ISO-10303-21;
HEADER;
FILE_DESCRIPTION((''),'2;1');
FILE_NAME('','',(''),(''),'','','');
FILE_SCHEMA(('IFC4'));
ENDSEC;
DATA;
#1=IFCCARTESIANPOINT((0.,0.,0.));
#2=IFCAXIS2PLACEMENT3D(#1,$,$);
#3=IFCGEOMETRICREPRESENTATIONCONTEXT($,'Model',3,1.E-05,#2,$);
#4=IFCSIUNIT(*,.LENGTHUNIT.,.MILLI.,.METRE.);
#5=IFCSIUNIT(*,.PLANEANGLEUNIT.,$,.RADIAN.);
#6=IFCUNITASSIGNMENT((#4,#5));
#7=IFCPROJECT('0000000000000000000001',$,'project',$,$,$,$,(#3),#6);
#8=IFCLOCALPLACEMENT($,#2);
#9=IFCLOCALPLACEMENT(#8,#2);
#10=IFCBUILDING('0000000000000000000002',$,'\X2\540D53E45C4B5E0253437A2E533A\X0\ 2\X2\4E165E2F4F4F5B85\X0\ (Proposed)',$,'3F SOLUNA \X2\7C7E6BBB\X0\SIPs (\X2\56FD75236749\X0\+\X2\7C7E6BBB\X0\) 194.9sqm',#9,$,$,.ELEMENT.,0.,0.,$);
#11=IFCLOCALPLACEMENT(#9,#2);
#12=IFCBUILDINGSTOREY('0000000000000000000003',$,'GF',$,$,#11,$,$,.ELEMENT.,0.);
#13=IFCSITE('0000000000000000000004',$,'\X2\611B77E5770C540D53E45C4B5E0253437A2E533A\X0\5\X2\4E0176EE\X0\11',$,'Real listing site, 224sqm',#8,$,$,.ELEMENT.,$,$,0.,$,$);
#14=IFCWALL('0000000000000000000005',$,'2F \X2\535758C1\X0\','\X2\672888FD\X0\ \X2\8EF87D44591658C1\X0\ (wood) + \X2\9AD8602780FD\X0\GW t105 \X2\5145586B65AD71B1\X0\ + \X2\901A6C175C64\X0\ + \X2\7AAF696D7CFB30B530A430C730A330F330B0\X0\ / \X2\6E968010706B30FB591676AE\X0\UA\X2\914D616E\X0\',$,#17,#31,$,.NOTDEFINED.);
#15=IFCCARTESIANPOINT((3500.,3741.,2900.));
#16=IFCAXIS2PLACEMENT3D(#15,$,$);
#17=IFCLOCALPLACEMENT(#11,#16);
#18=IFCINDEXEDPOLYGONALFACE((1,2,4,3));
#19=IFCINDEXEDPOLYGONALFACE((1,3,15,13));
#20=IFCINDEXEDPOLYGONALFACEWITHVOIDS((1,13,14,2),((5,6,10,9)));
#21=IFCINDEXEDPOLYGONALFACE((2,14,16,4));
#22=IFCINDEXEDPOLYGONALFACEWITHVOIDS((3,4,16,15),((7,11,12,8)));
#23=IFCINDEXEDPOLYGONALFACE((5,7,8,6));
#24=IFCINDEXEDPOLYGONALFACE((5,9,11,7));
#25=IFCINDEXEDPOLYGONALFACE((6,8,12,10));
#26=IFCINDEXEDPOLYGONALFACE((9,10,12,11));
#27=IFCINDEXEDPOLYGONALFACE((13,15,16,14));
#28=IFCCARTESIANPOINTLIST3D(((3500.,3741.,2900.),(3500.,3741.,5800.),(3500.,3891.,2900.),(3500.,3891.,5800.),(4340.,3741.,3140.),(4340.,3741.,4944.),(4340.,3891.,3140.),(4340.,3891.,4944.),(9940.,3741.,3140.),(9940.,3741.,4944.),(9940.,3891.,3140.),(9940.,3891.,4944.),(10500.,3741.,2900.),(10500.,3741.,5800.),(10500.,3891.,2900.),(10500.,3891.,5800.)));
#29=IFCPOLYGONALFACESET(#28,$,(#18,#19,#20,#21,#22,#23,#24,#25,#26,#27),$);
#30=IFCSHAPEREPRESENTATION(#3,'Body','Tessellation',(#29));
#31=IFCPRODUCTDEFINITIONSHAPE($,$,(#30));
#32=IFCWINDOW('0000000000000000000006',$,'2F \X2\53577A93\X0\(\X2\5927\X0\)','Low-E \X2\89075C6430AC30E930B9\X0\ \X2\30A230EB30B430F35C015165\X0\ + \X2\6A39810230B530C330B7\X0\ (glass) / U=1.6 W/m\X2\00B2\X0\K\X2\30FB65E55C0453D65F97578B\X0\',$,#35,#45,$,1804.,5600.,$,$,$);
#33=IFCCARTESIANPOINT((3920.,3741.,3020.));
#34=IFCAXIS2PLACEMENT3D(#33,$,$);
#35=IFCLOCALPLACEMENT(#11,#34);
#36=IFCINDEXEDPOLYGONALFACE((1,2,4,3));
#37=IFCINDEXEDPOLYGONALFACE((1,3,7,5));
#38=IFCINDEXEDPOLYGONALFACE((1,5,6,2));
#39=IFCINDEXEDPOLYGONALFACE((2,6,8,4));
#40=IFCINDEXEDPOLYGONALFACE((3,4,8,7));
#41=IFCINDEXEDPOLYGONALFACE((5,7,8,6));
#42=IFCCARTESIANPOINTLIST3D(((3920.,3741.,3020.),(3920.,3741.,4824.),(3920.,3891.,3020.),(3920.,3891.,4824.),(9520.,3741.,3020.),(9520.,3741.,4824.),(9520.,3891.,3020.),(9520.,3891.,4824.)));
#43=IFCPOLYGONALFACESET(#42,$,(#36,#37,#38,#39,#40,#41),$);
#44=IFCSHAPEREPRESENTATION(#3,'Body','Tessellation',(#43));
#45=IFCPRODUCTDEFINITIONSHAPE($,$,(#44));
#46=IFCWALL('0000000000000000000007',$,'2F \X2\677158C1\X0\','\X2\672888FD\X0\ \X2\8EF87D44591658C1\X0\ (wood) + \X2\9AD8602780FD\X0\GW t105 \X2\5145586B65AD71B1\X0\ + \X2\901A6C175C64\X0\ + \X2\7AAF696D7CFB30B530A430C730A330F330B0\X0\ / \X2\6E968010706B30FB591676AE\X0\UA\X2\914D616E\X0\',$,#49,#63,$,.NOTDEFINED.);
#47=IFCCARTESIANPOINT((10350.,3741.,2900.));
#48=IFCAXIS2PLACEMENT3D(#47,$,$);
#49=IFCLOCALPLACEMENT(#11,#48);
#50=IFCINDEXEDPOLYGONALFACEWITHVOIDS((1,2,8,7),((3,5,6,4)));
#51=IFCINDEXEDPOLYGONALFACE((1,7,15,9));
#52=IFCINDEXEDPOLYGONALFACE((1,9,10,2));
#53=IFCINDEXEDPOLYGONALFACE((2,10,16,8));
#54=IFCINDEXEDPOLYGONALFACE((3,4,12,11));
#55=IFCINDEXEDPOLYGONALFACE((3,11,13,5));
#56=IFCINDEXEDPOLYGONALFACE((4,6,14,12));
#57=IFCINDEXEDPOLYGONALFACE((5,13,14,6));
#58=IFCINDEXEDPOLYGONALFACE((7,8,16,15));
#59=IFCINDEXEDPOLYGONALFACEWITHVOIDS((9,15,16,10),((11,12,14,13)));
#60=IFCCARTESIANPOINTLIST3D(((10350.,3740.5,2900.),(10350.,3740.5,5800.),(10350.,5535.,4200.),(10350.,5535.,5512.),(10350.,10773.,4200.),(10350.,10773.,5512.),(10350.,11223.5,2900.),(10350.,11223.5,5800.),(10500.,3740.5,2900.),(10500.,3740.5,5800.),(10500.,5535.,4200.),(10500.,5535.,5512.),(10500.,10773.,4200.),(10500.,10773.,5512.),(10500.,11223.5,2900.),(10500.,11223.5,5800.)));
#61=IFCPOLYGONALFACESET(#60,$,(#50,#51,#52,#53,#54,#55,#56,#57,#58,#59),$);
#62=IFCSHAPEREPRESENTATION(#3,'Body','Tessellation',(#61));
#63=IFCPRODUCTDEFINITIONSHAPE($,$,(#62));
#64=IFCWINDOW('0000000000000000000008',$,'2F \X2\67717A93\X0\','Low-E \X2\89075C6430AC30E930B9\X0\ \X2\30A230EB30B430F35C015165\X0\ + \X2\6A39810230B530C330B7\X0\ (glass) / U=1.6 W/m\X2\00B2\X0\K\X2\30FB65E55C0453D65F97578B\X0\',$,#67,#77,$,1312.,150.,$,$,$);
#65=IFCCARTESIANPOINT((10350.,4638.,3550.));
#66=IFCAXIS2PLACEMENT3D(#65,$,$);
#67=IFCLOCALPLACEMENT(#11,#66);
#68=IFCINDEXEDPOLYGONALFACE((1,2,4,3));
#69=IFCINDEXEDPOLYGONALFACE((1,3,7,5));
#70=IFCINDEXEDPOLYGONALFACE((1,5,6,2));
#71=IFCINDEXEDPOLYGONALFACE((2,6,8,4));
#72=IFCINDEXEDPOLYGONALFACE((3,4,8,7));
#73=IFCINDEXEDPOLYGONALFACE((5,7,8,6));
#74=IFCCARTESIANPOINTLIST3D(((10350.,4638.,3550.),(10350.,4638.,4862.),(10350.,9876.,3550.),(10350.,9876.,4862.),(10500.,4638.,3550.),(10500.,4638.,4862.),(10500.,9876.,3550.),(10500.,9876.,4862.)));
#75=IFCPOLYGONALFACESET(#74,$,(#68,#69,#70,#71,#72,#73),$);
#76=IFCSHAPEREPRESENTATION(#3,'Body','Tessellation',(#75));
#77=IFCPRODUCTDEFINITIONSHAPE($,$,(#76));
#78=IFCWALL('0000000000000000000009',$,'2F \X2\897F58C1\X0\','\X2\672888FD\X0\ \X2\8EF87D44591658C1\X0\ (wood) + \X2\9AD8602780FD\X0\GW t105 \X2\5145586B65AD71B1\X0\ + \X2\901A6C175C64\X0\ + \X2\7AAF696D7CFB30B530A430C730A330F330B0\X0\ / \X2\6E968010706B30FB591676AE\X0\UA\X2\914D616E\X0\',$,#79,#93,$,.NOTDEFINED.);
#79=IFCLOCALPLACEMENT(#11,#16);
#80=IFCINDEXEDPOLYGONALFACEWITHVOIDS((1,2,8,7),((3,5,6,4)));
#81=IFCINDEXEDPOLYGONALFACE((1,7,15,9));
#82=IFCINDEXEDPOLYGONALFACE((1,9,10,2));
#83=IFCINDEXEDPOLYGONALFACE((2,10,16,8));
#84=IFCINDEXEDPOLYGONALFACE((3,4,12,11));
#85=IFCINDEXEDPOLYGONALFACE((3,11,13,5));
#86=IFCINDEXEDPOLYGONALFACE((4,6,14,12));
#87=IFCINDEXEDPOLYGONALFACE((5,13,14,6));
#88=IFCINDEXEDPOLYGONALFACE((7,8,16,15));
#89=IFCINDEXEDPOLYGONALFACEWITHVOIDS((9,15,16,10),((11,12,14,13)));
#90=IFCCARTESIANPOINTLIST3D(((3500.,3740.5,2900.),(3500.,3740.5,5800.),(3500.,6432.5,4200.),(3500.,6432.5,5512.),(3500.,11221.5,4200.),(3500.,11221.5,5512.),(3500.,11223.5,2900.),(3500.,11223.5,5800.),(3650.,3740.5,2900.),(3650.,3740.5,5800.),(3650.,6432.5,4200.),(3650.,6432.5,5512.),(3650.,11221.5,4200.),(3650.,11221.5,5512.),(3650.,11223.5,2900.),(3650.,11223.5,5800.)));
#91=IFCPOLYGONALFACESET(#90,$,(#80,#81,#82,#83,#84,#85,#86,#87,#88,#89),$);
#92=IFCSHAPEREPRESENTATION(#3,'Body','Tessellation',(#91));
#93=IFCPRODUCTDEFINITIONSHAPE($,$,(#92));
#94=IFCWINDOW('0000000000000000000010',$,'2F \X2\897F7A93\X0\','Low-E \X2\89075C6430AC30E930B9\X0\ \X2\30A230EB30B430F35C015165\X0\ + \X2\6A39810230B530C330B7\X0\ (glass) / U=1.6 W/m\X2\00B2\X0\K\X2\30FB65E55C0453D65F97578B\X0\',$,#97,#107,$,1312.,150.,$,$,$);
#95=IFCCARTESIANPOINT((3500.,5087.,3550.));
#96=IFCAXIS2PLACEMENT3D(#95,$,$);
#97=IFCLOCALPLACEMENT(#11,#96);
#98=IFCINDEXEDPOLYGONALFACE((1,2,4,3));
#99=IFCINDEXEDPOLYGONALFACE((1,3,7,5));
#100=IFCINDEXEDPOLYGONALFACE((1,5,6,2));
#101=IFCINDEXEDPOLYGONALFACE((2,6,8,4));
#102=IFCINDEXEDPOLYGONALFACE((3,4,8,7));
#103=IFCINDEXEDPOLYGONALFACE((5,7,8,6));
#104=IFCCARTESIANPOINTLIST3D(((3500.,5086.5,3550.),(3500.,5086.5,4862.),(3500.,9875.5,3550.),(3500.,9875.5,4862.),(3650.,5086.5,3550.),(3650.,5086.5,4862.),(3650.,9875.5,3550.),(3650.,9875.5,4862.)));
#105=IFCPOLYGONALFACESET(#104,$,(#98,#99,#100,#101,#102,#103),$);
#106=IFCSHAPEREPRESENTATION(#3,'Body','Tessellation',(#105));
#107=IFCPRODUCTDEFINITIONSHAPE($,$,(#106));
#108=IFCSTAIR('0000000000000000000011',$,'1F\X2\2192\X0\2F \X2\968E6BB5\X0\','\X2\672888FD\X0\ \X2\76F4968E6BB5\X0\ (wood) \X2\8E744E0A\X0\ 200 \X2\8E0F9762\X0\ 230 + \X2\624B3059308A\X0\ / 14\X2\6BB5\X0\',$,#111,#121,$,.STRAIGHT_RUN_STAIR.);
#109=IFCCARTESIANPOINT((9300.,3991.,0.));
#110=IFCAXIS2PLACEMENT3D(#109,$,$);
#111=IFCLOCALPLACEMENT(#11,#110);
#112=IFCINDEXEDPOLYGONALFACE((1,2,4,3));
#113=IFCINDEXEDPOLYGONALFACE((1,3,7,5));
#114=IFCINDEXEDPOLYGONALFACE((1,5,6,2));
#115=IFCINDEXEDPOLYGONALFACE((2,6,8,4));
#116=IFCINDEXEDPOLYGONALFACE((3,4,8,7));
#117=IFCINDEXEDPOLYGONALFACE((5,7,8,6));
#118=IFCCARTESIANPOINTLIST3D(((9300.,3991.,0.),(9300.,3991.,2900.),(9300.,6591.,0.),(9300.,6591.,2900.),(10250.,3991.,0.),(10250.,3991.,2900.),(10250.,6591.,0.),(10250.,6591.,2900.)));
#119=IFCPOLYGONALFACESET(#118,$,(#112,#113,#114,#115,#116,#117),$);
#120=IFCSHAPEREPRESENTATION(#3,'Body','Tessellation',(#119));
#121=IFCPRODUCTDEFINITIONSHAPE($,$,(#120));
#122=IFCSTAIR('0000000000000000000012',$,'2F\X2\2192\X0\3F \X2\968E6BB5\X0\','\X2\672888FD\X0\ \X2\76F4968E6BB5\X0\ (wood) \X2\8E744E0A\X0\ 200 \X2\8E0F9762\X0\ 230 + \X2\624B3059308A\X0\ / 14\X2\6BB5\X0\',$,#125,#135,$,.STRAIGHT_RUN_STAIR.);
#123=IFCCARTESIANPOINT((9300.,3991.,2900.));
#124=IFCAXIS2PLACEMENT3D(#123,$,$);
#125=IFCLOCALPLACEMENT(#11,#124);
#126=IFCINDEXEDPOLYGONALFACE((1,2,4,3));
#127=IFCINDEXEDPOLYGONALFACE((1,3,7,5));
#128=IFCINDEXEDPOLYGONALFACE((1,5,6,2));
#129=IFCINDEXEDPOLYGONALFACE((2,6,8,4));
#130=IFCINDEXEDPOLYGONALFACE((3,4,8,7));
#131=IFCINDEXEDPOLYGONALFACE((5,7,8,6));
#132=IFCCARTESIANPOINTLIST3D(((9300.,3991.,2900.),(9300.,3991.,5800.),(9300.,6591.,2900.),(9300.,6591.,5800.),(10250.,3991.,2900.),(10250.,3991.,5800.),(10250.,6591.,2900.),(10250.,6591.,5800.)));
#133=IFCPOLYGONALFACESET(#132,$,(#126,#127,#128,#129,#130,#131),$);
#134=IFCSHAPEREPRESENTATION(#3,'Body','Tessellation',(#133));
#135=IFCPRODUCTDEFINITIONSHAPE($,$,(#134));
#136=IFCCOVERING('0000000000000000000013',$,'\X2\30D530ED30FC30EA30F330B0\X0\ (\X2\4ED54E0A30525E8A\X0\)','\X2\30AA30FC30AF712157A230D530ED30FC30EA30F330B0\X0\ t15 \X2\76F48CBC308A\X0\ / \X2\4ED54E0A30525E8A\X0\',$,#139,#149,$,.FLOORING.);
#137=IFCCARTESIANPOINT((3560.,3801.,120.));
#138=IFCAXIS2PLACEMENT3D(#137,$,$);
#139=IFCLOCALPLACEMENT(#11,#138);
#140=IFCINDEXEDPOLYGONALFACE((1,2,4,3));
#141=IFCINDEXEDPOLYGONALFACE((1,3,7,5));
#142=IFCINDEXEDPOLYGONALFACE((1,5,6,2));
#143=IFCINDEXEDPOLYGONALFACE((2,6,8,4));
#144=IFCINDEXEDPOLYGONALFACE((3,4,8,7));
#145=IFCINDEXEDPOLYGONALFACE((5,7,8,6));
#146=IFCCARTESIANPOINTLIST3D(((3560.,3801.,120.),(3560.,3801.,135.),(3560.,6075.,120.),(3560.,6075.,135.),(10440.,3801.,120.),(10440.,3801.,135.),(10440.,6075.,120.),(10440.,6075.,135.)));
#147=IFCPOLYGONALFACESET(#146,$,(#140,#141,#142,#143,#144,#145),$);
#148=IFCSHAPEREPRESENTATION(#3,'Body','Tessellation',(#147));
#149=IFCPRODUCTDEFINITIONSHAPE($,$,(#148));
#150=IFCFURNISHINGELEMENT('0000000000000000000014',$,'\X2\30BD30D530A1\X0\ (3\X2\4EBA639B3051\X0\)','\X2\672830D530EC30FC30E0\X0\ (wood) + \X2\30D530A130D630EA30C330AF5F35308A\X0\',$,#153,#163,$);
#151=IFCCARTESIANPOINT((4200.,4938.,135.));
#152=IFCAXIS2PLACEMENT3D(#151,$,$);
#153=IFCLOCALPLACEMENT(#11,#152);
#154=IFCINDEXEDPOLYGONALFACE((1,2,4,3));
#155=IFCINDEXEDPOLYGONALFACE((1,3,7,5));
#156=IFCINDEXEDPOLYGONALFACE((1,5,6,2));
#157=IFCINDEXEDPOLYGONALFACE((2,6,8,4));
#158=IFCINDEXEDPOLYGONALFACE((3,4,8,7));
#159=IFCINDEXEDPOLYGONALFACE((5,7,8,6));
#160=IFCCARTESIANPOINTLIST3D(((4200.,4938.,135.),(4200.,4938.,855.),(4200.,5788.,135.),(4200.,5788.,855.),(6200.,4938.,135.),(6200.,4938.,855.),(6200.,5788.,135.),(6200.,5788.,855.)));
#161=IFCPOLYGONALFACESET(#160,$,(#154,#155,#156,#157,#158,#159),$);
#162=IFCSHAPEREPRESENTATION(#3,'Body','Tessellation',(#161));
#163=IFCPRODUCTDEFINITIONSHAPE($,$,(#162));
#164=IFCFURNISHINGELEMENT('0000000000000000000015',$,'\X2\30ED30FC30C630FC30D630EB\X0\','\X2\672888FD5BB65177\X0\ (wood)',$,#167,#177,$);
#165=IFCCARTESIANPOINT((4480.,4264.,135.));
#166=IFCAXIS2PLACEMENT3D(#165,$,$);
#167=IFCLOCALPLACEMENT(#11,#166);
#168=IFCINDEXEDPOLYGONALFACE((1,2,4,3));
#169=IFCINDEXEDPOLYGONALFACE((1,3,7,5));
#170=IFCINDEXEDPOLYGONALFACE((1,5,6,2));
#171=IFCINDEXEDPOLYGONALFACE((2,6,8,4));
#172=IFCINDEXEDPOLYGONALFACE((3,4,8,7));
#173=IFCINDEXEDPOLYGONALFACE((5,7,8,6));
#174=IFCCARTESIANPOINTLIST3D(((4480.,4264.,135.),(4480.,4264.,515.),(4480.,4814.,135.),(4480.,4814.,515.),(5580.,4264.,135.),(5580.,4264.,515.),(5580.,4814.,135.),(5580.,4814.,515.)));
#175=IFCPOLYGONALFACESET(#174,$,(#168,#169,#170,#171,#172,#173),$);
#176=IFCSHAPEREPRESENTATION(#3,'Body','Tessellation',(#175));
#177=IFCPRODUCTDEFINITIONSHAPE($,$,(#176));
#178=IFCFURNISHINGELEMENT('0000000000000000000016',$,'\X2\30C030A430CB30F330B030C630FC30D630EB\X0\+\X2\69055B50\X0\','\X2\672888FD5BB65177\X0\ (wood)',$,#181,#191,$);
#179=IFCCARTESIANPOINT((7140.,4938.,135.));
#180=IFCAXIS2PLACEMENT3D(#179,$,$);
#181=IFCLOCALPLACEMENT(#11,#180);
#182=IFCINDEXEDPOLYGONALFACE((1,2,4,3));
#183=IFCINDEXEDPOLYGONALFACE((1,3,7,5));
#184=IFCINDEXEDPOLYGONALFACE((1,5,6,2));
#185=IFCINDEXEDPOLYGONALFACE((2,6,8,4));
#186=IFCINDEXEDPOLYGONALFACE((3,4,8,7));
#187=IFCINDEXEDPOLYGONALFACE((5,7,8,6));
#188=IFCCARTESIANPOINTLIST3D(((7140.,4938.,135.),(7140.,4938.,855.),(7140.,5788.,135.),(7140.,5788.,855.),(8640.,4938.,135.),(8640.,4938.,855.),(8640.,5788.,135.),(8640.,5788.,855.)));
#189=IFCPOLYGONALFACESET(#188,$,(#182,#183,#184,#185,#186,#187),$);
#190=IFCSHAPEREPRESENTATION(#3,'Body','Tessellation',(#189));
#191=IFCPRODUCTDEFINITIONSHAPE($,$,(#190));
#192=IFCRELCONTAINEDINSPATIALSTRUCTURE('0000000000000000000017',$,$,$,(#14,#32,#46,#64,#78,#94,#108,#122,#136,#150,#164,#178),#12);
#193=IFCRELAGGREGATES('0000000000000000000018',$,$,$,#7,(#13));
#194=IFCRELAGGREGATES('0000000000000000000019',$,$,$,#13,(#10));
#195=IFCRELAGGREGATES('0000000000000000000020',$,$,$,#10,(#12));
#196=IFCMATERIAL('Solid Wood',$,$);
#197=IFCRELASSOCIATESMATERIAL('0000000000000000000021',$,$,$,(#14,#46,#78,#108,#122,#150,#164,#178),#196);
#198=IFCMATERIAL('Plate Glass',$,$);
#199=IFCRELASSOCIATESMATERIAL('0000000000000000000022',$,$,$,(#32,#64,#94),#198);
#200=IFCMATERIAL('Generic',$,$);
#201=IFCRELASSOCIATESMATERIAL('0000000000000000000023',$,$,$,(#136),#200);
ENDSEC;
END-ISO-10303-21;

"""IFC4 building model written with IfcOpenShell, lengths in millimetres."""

from ifc_helpers import new_model, si_unit, frame, frame_2d, origin, place, context, project, spatial, rectangle, extrude, material, element, fill, save


model = new_model("IFC4")

# Units and contexts
model_context = context("Model", 3, precision=1e-05, world=origin())
ifc_project = project(units=[si_unit("LENGTHUNIT", "METRE", prefix="MILLI"), si_unit("PLANEANGLEUNIT", "RADIAN")], contexts=[model_context])

# Site, building, storey
site_placement = place(None, origin())
site = spatial("IfcSite", under=ifc_project, at=site_placement, Name="愛知県名古屋市千種区5丁目11", ObjectType="Real listing site, 224sqm", CompositionType="ELEMENT", RefElevation=0.0)
building_placement = place(site_placement, origin())
building = spatial("IfcBuilding", under=site, at=building_placement, Name="名古屋市千種区 2世帯住宅 (Proposed)", ObjectType="3F SOLUNA 籾殻SIPs (国産杉+籾殻) 194.9sqm", CompositionType="ELEMENT", ElevationOfRefHeight=0.0, ElevationOfTerrain=0.0)
storey_placement = place(building_placement, origin())
storey = spatial("IfcBuildingStorey", under=building, at=storey_placement, Name="GF", CompositionType="ELEMENT", Elevation=0.0)

# Shared definitions
ifc_material_1 = material(Name="Solid Wood")

# Shared definitions
ifc_material_2 = material(Name="Plate Glass")

# Walls, openings, windows
wall_1_placement = place(storey_placement, frame((3500.0, 3741.0, 2900.0)))
wall_1 = element("IfcWall", 1, at=wall_1_placement, inside=storey, material=ifc_material_1, Name="2F 南壁", Description="木製 軸組外壁 (wood) + 高性能GW t105 充填断熱 + 通気層 + 窯業系サイディング / 準耐火・外皮UA配慮", PredefinedType="NOTDEFINED", context=model_context, shape_type="SweptSolid", body=[
    extrude(rectangle(XDim=7000.0, YDim=150.0, at=frame_2d((3500.0, 75.0))), frame((3500.0, 3741.0, 2900.0)), (0.0, 0.0, 1.0), 2900.0),
])
opening_1_placement = place(storey_placement, frame((3920.0, 3741.0, 3020.0)))
opening_1 = element("IfcOpeningElement", 2, at=opening_1_placement, cuts=wall_1, PredefinedType="NOTDEFINED", context=model_context, shape_type="SweptSolid", body=[
    extrude(rectangle(XDim=5600.0, YDim=150.0, at=frame_2d((2800.0, 75.0))), frame((3920.0, 3741.0, 3020.0)), (0.0, 0.0, 1.0), 1804.0),
])
window_1_placement = place(storey_placement, frame((3920.0, 3741.0, 3020.0)))
window_1 = element("IfcWindow", 3, at=window_1_placement, inside=storey, material=ifc_material_2, Name="2F 南窓(大)", Description="Low-E 複層ガラス アルゴン封入 + 樹脂サッシ (glass) / U=1.6 W/m²K・日射取得型", OverallHeight=1804.0, OverallWidth=5600.0, context=model_context, shape_type="SweptSolid", body=[
    extrude(rectangle(XDim=5600.0, YDim=150.0, at=frame_2d((2800.0, 75.0))), frame((3920.0, 3741.0, 3020.0)), (0.0, 0.0, 1.0), 1804.0),
])
fill(opening_1, window_1)
wall_2_placement = place(storey_placement, frame((10350.0, 3741.0, 2900.0)))
wall_2 = element("IfcWall", 4, at=wall_2_placement, inside=storey, material=ifc_material_1, Name="2F 東壁", Description="木製 軸組外壁 (wood) + 高性能GW t105 充填断熱 + 通気層 + 窯業系サイディング / 準耐火・外皮UA配慮", PredefinedType="NOTDEFINED", context=model_context, shape_type="SweptSolid", body=[
    extrude(rectangle(XDim=150.0, YDim=7483.0, at=frame_2d((75.0, 3741.0))), frame((10350.0, 3741.0, 2900.0)), (0.0, 0.0, 1.0), 2900.0),
])
opening_2_placement = place(storey_placement, frame((10350.0, 4638.0, 3550.0)))
opening_2 = element("IfcOpeningElement", 5, at=opening_2_placement, cuts=wall_2, PredefinedType="NOTDEFINED", context=model_context, shape_type="SweptSolid", body=[
    extrude(rectangle(XDim=150.0, YDim=5238.0, at=frame_2d((75.0, 2619.0))), frame((10350.0, 4638.0, 3550.0)), (0.0, 0.0, 1.0), 1312.0),
])
window_2_placement = place(storey_placement, frame((10350.0, 4638.0, 3550.0)))
window_2 = element("IfcWindow", 6, at=window_2_placement, inside=storey, material=ifc_material_2, Name="2F 東窓", Description="Low-E 複層ガラス アルゴン封入 + 樹脂サッシ (glass) / U=1.6 W/m²K・日射取得型", OverallHeight=1312.0, OverallWidth=150.0, context=model_context, shape_type="SweptSolid", body=[
    extrude(rectangle(XDim=150.0, YDim=5238.0, at=frame_2d((75.0, 2619.0))), frame((10350.0, 4638.0, 3550.0)), (0.0, 0.0, 1.0), 1312.0),
])
fill(opening_2, window_2)
wall_3_placement = place(storey_placement, frame((3500.0, 3741.0, 2900.0)))
wall_3 = element("IfcWall", 7, at=wall_3_placement, inside=storey, material=ifc_material_1, Name="2F 西壁", Description="木製 軸組外壁 (wood) + 高性能GW t105 充填断熱 + 通気層 + 窯業系サイディング / 準耐火・外皮UA配慮", PredefinedType="NOTDEFINED", context=model_context, shape_type="SweptSolid", body=[
    extrude(rectangle(XDim=150.0, YDim=7483.0, at=frame_2d((75.0, 3741.0))), frame((3500.0, 3741.0, 2900.0)), (0.0, 0.0, 1.0), 2900.0),
])
opening_3_placement = place(storey_placement, frame((3500.0, 5087.0, 3550.0)))
opening_3 = element("IfcOpeningElement", 8, at=opening_3_placement, cuts=wall_3, PredefinedType="NOTDEFINED", context=model_context, shape_type="SweptSolid", body=[
    extrude(rectangle(XDim=150.0, YDim=4789.0, at=frame_2d((75.0, 2394.0))), frame((3500.0, 5087.0, 3550.0)), (0.0, 0.0, 1.0), 1312.0),
])
window_3_placement = place(storey_placement, frame((3500.0, 5087.0, 3550.0)))
window_3 = element("IfcWindow", 9, at=window_3_placement, inside=storey, material=ifc_material_2, Name="2F 西窓", Description="Low-E 複層ガラス アルゴン封入 + 樹脂サッシ (glass) / U=1.6 W/m²K・日射取得型", OverallHeight=1312.0, OverallWidth=150.0, context=model_context, shape_type="SweptSolid", body=[
    extrude(rectangle(XDim=150.0, YDim=4789.0, at=frame_2d((75.0, 2394.0))), frame((3500.0, 5087.0, 3550.0)), (0.0, 0.0, 1.0), 1312.0),
])
fill(opening_3, window_3)

# Stairs
stair_1_placement = place(storey_placement, frame((9300.0, 3991.0, 0.0)))
element("IfcStair", 10, at=stair_1_placement, inside=storey, material=ifc_material_1, Name="1F→2F 階段", Description="木製 直階段 (wood) 蹴上 200 踏面 230 + 手すり / 14段", PredefinedType="STRAIGHT_RUN_STAIR", context=model_context, shape_type="SweptSolid", body=[
    extrude(rectangle(XDim=950.0, YDim=2600.0, at=frame_2d((475.0, 1300.0))), frame((9300.0, 3991.0, 0.0)), (0.0, 0.0, 1.0), 2900.0),
])
stair_2_placement = place(storey_placement, frame((9300.0, 3991.0, 2900.0)))
element("IfcStair", 11, at=stair_2_placement, inside=storey, material=ifc_material_1, Name="2F→3F 階段", Description="木製 直階段 (wood) 蹴上 200 踏面 230 + 手すり / 14段", PredefinedType="STRAIGHT_RUN_STAIR", context=model_context, shape_type="SweptSolid", body=[
    extrude(rectangle(XDim=950.0, YDim=2600.0, at=frame_2d((475.0, 1300.0))), frame((9300.0, 3991.0, 2900.0)), (0.0, 0.0, 1.0), 2900.0),
])

# Covering
ifc_material_3 = material(Name="Generic")
covering_placement = place(storey_placement, frame((3560.0, 3801.0, 120.0)))
element("IfcCovering", 12, at=covering_placement, inside=storey, material=ifc_material_3, Name="フローリング (仕上げ床)", Description="オーク無垢フローリング t15 直貼り / 仕上げ床", PredefinedType="FLOORING", context=model_context, shape_type="SweptSolid", body=[
    extrude(rectangle(XDim=6880.0, YDim=2274.0, at=frame_2d((3440.0, 1137.0))), frame((3560.0, 3801.0, 120.0)), (0.0, 0.0, 1.0), 15.0),
])

# Furnishing elements
furnishing_1_placement = place(storey_placement, frame((4200.0, 4938.0, 135.0)))
element("IfcFurnishingElement", 13, at=furnishing_1_placement, inside=storey, material=ifc_material_1, Name="ソファ (3人掛け)", Description="木フレーム (wood) + ファブリック張り", context=model_context, shape_type="SweptSolid", body=[
    extrude(rectangle(XDim=2000.0, YDim=850.0, at=frame_2d((1000.0, 425.0))), frame((4200.0, 4938.0, 135.0)), (0.0, 0.0, 1.0), 720.0),
])
furnishing_2_placement = place(storey_placement, frame((4480.0, 4264.0, 135.0)))
element("IfcFurnishingElement", 14, at=furnishing_2_placement, inside=storey, material=ifc_material_1, Name="ローテーブル", Description="木製家具 (wood)", context=model_context, shape_type="SweptSolid", body=[
    extrude(rectangle(XDim=1100.0, YDim=550.0, at=frame_2d((550.0, 275.0))), frame((4480.0, 4264.0, 135.0)), (0.0, 0.0, 1.0), 380.0),
])
furnishing_3_placement = place(storey_placement, frame((7140.0, 4938.0, 135.0)))
element("IfcFurnishingElement", 15, at=furnishing_3_placement, inside=storey, material=ifc_material_1, Name="ダイニングテーブル+椅子", Description="木製家具 (wood)", context=model_context, shape_type="SweptSolid", body=[
    extrude(rectangle(XDim=1500.0, YDim=850.0, at=frame_2d((750.0, 425.0))), frame((7140.0, 4938.0, 135.0)), (0.0, 0.0, 1.0), 720.0),
])

save(model, "model.ifc")
